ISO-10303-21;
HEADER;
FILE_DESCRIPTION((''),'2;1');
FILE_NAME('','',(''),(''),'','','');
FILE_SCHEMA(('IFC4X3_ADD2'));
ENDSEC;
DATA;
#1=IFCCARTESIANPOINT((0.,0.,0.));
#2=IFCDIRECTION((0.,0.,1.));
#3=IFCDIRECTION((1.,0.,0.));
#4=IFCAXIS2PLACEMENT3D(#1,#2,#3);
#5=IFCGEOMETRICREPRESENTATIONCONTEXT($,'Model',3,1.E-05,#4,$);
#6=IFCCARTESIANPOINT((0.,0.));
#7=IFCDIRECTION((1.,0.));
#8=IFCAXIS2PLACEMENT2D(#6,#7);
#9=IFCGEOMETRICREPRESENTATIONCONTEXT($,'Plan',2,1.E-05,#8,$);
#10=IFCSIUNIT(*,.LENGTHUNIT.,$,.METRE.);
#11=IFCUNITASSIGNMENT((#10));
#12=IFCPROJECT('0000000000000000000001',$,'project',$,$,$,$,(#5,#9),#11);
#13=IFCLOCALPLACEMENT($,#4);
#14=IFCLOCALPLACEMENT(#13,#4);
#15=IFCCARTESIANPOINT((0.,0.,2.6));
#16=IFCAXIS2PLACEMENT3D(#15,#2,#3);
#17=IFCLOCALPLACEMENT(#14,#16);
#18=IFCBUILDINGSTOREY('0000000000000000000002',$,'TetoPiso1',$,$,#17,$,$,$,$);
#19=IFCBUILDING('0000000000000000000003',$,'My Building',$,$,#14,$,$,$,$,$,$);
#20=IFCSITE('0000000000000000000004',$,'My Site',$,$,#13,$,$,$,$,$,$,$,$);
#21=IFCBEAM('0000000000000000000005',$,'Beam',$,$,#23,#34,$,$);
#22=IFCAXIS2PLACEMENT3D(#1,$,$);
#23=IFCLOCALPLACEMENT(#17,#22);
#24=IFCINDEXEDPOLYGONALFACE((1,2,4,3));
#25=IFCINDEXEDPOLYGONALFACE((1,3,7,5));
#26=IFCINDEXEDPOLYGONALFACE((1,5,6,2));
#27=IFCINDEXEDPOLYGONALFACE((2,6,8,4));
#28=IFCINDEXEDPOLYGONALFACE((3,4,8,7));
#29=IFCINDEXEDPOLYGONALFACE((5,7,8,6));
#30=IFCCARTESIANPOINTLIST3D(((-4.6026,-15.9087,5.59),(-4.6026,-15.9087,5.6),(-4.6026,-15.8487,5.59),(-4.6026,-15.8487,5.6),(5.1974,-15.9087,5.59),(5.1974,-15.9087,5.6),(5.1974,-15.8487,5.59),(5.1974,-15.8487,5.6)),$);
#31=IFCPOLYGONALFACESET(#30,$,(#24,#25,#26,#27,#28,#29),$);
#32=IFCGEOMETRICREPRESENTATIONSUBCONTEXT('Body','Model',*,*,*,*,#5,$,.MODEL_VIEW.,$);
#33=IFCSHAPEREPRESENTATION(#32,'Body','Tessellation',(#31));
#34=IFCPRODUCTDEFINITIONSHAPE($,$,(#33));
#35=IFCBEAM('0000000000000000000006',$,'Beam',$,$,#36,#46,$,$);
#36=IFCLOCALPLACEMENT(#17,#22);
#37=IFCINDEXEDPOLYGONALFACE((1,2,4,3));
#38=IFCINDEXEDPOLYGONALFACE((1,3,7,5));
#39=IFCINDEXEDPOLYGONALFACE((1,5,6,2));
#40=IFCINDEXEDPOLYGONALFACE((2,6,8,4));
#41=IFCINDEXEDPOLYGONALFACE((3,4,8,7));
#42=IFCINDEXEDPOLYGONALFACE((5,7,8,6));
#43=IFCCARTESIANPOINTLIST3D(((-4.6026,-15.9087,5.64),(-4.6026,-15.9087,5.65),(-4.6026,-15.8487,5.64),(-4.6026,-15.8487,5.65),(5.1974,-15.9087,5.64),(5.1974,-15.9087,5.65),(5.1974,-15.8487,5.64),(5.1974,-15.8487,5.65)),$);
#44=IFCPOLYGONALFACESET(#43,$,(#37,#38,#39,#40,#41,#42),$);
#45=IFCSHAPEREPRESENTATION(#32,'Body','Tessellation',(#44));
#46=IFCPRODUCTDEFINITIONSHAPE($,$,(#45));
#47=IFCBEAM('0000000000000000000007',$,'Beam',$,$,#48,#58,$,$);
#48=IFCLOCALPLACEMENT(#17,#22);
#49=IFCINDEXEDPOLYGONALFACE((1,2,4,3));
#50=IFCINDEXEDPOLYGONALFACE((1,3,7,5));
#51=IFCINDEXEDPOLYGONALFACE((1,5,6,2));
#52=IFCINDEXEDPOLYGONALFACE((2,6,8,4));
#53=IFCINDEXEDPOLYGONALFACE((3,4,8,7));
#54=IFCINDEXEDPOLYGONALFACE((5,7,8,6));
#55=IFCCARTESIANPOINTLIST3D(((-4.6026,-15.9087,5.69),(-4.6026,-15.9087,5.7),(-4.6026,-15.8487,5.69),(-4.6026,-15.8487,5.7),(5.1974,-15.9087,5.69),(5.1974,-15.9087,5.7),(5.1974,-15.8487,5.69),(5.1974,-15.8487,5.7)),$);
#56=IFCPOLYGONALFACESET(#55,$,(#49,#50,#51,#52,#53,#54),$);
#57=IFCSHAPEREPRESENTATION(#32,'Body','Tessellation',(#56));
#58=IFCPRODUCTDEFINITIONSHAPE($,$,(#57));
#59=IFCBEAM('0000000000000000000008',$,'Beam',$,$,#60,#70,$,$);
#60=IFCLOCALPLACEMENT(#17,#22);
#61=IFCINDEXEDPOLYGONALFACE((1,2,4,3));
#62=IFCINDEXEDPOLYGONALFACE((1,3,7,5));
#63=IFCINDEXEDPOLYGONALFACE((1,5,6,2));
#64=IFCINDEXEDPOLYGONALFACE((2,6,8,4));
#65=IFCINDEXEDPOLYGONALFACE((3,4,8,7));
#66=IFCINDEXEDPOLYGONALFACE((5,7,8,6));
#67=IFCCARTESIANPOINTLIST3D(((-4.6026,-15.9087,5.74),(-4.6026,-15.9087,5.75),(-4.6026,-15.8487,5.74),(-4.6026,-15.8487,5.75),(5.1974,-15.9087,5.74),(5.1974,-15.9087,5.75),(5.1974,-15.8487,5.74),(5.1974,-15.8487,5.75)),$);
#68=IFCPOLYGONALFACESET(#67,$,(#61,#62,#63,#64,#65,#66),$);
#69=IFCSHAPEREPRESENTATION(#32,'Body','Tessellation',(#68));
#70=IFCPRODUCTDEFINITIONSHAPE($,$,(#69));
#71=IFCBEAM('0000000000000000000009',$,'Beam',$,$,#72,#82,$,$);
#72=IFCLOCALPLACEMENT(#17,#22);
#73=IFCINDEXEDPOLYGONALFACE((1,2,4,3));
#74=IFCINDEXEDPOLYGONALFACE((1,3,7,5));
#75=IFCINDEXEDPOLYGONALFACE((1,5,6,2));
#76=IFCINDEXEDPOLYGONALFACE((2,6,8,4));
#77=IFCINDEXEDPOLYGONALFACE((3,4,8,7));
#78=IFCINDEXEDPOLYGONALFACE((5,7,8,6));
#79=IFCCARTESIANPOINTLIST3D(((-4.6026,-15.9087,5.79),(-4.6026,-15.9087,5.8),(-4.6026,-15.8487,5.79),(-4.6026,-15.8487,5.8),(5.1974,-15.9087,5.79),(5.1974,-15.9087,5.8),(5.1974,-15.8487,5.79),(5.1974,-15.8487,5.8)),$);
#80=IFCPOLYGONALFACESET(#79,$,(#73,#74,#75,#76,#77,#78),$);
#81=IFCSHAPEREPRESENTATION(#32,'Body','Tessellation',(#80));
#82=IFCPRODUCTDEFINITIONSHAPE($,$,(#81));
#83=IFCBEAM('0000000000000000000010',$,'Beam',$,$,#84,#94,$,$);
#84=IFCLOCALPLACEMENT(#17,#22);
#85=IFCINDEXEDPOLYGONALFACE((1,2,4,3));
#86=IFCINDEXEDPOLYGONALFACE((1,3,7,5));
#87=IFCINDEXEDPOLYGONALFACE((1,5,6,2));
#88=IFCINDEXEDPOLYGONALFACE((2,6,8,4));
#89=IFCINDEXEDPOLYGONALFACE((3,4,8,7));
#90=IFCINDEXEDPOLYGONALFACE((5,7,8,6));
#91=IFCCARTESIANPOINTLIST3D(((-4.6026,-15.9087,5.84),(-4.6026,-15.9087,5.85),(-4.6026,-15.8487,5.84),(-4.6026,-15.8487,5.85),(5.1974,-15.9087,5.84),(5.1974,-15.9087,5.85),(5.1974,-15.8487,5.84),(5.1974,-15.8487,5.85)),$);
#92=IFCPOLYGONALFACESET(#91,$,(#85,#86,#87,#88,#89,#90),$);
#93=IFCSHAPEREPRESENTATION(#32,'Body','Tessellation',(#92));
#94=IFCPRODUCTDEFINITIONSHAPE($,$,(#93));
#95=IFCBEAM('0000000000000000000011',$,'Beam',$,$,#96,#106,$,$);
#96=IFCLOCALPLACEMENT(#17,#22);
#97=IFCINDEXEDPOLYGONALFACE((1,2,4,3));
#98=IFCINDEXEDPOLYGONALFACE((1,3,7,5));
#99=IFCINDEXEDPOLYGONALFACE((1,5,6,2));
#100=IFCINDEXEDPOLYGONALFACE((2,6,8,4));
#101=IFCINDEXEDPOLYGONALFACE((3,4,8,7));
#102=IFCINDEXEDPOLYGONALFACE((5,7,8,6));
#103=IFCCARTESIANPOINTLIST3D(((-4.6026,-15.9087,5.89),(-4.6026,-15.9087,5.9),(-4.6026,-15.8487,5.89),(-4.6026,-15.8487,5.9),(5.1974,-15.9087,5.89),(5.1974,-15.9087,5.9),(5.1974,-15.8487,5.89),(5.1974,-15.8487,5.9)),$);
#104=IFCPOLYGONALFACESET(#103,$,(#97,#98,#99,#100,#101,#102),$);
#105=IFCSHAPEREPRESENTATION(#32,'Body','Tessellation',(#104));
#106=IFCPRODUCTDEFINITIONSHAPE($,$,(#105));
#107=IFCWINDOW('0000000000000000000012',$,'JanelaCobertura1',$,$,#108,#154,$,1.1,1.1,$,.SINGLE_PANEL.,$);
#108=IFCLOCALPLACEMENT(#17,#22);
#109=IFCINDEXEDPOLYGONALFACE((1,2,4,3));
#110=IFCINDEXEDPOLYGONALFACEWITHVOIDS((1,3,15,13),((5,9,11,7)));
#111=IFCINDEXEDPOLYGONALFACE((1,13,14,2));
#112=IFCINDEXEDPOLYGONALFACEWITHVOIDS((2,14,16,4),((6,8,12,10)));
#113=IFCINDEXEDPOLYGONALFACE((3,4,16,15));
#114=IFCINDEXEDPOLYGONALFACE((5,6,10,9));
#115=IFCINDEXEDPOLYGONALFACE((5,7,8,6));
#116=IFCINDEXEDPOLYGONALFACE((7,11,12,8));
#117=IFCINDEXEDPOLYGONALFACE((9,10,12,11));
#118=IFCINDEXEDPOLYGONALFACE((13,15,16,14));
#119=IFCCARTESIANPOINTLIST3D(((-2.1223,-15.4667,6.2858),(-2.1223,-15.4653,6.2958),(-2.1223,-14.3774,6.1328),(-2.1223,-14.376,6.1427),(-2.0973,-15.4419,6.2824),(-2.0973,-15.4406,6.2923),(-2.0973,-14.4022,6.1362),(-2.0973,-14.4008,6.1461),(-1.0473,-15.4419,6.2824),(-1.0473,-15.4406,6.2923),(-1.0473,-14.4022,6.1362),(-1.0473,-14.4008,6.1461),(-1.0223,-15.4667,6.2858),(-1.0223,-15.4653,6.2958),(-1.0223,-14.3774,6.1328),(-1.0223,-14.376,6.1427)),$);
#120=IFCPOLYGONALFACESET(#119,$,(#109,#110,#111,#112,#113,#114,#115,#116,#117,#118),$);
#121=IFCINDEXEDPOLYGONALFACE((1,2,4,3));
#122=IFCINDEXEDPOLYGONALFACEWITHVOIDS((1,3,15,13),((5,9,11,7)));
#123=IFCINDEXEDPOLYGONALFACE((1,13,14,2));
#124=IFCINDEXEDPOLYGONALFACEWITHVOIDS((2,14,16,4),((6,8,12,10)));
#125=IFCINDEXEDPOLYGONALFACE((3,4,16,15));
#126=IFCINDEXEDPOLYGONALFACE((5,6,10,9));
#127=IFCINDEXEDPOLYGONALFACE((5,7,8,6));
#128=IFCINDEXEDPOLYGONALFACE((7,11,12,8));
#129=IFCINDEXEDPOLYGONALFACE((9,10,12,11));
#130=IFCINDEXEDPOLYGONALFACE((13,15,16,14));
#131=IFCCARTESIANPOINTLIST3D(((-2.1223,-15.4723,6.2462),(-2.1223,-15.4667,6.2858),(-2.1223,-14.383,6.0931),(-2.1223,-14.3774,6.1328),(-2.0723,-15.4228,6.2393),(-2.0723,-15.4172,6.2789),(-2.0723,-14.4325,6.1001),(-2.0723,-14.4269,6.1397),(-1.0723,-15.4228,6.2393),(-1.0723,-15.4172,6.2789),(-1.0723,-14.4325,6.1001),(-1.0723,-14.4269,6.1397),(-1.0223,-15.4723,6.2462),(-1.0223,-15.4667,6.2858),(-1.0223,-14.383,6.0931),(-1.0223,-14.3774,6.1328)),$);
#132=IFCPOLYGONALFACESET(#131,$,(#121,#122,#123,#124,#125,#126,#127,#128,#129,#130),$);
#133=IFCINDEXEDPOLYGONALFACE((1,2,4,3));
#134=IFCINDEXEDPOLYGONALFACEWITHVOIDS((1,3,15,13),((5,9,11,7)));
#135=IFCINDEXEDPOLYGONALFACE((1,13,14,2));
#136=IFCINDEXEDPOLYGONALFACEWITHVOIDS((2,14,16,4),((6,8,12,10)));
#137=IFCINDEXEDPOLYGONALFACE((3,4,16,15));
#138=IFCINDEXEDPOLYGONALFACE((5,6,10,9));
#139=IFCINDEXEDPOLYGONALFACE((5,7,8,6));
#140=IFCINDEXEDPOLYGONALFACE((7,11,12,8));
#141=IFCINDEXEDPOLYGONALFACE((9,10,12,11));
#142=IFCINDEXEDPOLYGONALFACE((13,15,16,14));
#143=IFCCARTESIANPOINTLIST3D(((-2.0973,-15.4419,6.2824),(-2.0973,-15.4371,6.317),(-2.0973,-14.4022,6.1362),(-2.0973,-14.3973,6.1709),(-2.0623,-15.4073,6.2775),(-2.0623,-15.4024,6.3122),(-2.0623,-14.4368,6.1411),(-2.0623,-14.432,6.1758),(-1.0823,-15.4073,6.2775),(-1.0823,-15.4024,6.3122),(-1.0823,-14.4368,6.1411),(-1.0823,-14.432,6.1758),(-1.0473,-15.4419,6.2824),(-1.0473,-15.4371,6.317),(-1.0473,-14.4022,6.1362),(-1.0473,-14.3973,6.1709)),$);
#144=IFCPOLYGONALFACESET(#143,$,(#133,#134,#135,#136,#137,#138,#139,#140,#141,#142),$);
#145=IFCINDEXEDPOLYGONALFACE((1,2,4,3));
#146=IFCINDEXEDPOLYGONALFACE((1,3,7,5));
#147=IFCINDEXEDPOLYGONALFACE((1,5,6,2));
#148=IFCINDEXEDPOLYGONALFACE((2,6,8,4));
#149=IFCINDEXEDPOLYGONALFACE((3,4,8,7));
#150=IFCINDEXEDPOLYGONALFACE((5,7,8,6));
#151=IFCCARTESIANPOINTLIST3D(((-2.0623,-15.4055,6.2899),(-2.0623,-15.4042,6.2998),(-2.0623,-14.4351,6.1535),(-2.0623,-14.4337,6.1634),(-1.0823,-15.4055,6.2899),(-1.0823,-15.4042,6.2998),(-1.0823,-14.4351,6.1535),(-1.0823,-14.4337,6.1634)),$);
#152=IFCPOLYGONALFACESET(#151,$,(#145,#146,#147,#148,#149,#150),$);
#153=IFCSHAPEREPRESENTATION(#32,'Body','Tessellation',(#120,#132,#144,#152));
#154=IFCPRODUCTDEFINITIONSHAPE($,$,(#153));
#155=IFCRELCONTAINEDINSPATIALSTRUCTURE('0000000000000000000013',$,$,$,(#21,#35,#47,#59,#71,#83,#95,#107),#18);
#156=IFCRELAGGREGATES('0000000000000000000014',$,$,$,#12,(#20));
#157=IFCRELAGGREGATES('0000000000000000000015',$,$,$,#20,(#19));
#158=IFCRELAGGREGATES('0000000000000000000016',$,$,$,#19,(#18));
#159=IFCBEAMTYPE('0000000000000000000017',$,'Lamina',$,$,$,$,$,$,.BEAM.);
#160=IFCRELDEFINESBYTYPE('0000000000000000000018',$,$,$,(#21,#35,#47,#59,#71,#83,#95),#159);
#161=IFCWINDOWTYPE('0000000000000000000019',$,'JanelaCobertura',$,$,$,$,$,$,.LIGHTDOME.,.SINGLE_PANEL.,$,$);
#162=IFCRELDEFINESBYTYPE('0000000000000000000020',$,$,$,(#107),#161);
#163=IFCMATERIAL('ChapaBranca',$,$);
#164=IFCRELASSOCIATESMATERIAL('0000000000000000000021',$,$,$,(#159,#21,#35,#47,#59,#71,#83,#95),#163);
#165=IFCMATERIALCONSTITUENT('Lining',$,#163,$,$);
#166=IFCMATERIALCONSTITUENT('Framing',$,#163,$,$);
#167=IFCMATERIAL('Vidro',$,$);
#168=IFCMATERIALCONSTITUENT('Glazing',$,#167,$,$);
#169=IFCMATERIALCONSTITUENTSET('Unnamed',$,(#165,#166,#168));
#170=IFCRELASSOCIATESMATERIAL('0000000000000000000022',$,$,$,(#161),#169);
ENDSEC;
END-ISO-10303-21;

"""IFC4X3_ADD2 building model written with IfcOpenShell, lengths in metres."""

from ifc_helpers import new_model, entity, si_unit, frame, origin_with_axes, origin_2d, origin_2d_with_axis, place, context, subcontext, project, spatial, line, indexed_curve, rectangle, outline, extrude, shape, source, transform, mapped, material, constituent, constituent_set, material_profile, profile_set, profile_usage, type_object, type_shapes, element, save


model = new_model("IFC4X3_ADD2")

# Units and contexts
model_context = context("Model", 3, precision=1e-05, world=origin_with_axes())
plan_context = context("Plan", 2, precision=1e-05, world=origin_2d_with_axis())
body_context_1 = subcontext(model_context, "Body", "Model", "MODEL_VIEW")
body_context_2 = subcontext(plan_context, "Body", "Plan", "PLAN_VIEW")
ifc_project = project(units=[si_unit("LENGTHUNIT", "METRE")], contexts=[model_context, plan_context])

# Site, building, storey
site_placement = place(None, origin_with_axes())
site = spatial("IfcSite", under=ifc_project, at=site_placement, Name="My Site")
building_placement = place(site_placement, origin_with_axes())
building = spatial("IfcBuilding", under=site, at=building_placement, Name="My Building")
storey_placement = place(building_placement, frame((0.0, 0.0, 2.6), z_axis=(0.0, 0.0, 1.0), x_axis=(1.0, 0.0, 0.0)))
storey = spatial("IfcBuildingStorey", under=building, at=storey_placement, Name="TetoPiso1")

# Beams
ifc_material_1 = material(Name="ChapaBranca")
ifc_material_profile_1 = material_profile(ifc_material_1, rectangle(XDim=0.06, YDim=0.01, at=origin_2d()))
ifc_profile_set_1 = profile_set([ifc_material_profile_1])
beam_type_1 = type_object("IfcBeamType", Name="Lamina", PredefinedType="BEAM", material=ifc_profile_set_1)
ifc_profile_usage_1 = profile_usage(ifc_profile_set_1, cardinal=5)
beam_1_placement = place(storey_placement, frame((-4.6026, -15.8787, 5.595), z_axis=(1.0, 0.0, 0.0), x_axis=(0.0, 1.0, 0.0)))
element("IfcBeam", 1, at=beam_1_placement, inside=storey, type_object=beam_type_1, material=ifc_profile_usage_1, Name="Beam", context=body_context_1, shape_type="SweptSolid", body=[
    extrude(rectangle(XDim=0.06, YDim=0.01, at=origin_2d()), origin_with_axes(), (0.0, 0.0, 1.0), 9.8),
])
ifc_profile_usage_2 = profile_usage(ifc_profile_set_1, cardinal=5)
beam_2_placement = place(storey_placement, frame((-4.6026, -15.8787, 5.645), z_axis=(1.0, 0.0, 0.0), x_axis=(0.0, 1.0, 0.0)))
element("IfcBeam", 2, at=beam_2_placement, inside=storey, type_object=beam_type_1, material=ifc_profile_usage_2, Name="Beam", context=body_context_1, shape_type="SweptSolid", body=[
    extrude(rectangle(XDim=0.06, YDim=0.01, at=origin_2d()), origin_with_axes(), (0.0, 0.0, 1.0), 9.8),
])
ifc_profile_usage_3 = profile_usage(ifc_profile_set_1, cardinal=5)
beam_3_placement = place(storey_placement, frame((-4.6026, -15.8787, 5.695), z_axis=(1.0, 0.0, 0.0), x_axis=(0.0, 1.0, 0.0)))
element("IfcBeam", 3, at=beam_3_placement, inside=storey, type_object=beam_type_1, material=ifc_profile_usage_3, Name="Beam", context=body_context_1, shape_type="SweptSolid", body=[
    extrude(rectangle(XDim=0.06, YDim=0.01, at=origin_2d()), origin_with_axes(), (0.0, 0.0, 1.0), 9.8),
])
ifc_profile_usage_4 = profile_usage(ifc_profile_set_1, cardinal=5)
beam_4_placement = place(storey_placement, frame((-4.6026, -15.8787, 5.745), z_axis=(1.0, 0.0, 0.0), x_axis=(0.0, 1.0, 0.0)))
element("IfcBeam", 4, at=beam_4_placement, inside=storey, type_object=beam_type_1, material=ifc_profile_usage_4, Name="Beam", context=body_context_1, shape_type="SweptSolid", body=[
    extrude(rectangle(XDim=0.06, YDim=0.01, at=origin_2d()), origin_with_axes(), (0.0, 0.0, 1.0), 9.8),
])
ifc_profile_usage_5 = profile_usage(ifc_profile_set_1, cardinal=5)
beam_5_placement = place(storey_placement, frame((-4.6026, -15.8787, 5.795), z_axis=(1.0, 0.0, 0.0), x_axis=(0.0, 1.0, 0.0)))
element("IfcBeam", 5, at=beam_5_placement, inside=storey, type_object=beam_type_1, material=ifc_profile_usage_5, Name="Beam", context=body_context_1, shape_type="SweptSolid", body=[
    extrude(rectangle(XDim=0.06, YDim=0.01, at=origin_2d()), origin_with_axes(), (0.0, 0.0, 1.0), 9.8),
])
ifc_profile_usage_6 = profile_usage(ifc_profile_set_1, cardinal=5)
beam_6_placement = place(storey_placement, frame((-4.6026, -15.8787, 5.845), z_axis=(1.0, 0.0, 0.0), x_axis=(0.0, 1.0, 0.0)))
element("IfcBeam", 6, at=beam_6_placement, inside=storey, type_object=beam_type_1, material=ifc_profile_usage_6, Name="Beam", context=body_context_1, shape_type="SweptSolid", body=[
    extrude(rectangle(XDim=0.06, YDim=0.01, at=origin_2d()), origin_with_axes(), (0.0, 0.0, 1.0), 9.8),
])
ifc_profile_usage_7 = profile_usage(ifc_profile_set_1, cardinal=5)
beam_7_placement = place(storey_placement, frame((-4.6026, -15.8787, 5.895), z_axis=(1.0, 0.0, 0.0), x_axis=(0.0, 1.0, 0.0)))
element("IfcBeam", 7, at=beam_7_placement, inside=storey, type_object=beam_type_1, material=ifc_profile_usage_7, Name="Beam", context=body_context_1, shape_type="SweptSolid", body=[
    extrude(rectangle(XDim=0.06, YDim=0.01, at=origin_2d()), origin_with_axes(), (0.0, 0.0, 1.0), 9.8),
])

# Window
ifc_constituent_1 = constituent(ifc_material_1, Name="Lining")
ifc_constituent_2 = constituent(ifc_material_1, Name="Framing")
ifc_material_2 = material(Name="Vidro")
ifc_constituent_3 = constituent(ifc_material_2, Name="Glazing")
ifc_constituent_set = constituent_set(constituents=[ifc_constituent_1, ifc_constituent_2, ifc_constituent_3], Name="Unnamed")
window_type = type_object("IfcWindowType", Name="JanelaCobertura", PartitioningType="SINGLE_PANEL", PredefinedType="LIGHTDOME", material=ifc_constituent_set)
shared_shape_1 = source(origin_with_axes(), body_context_1, "Body", "SweptSolid", [
    extrude(outline(indexed_curve([(0.0, 0.0), (1.1, 0.0), (1.1, 1.1), (0.0, 1.1)], segments=[line(1, 2, 3, 4, 1)]), holes=[indexed_curve([(0.025, 0.025), (1.075, 0.025), (1.075, 1.075), (0.025, 1.075)], segments=[line(1, 2, 3, 4, 1)])]), frame((0.0, 0.09, 0.0), z_axis=(0.0, -1.0, 0.0), x_axis=(1.0, 0.0, 0.0)), (0.0, 0.0, -1.0), 0.01),
    extrude(outline(indexed_curve([(0.0, 0.0), (1.1, 0.0), (1.1, 1.1), (0.0, 1.1)], segments=[line(1, 2, 3, 4, 1)]), holes=[indexed_curve([(0.05, 0.05), (1.05, 0.05), (1.05, 1.05), (0.05, 1.05)], segments=[line(1, 2, 3, 4, 1)])]), frame((0.0, 0.05, 0.0), z_axis=(0.0, -1.0, 0.0), x_axis=(1.0, 0.0, 0.0)), (0.0, 0.0, -1.0), 0.04),
    extrude(outline(indexed_curve([(0.0, 0.0), (1.05, 0.0), (1.05, 1.05), (0.0, 1.05)], segments=[line(1, 2, 3, 4, 1)]), holes=[indexed_curve([(0.035, 0.035), (1.015, 0.035), (1.015, 1.015), (0.035, 1.015)], segments=[line(1, 2, 3, 4, 1)])]), frame((0.025, 0.09, 0.025), z_axis=(0.0, -1.0, 0.0), x_axis=(1.0, 0.0, 0.0)), (0.0, 0.0, -1.0), 0.035),
    extrude(outline(indexed_curve([(0.035, 0.035), (1.015, 0.035), (1.015, 1.015), (0.035, 1.015)], segments=[line(1, 2, 3, 4, 1)])), frame((0.025, 0.1025, 0.025), z_axis=(0.0, -1.0, 0.0), x_axis=(1.0, 0.0, 0.0)), (0.0, 0.0, -1.0), 0.01),
])
shared_shape_2 = source(origin_with_axes(), body_context_2, "Body", "Curve2D", [
    entity("IfcIndexedPolyCurve", entity("IfcCartesianPointList2D", [[0.05, 0.05], [1.05, 0.05]])),
    entity("IfcIndexedPolyCurve", entity("IfcCartesianPointList2D", [[0.0, 0.1], [0.025, 0.1], [0.025, 0.09], [0.05, 0.09], [0.05, 0.05], [0.0, 0.05]]), [entity("IfcLineIndex", [1, 2, 3, 4, 5, 6, 1])]),
    entity("IfcIndexedPolyCurve", entity("IfcCartesianPointList2D", [[1.1, 0.1], [1.075, 0.1], [1.075, 0.09], [1.05, 0.09], [1.05, 0.05], [1.1, 0.05]]), [entity("IfcLineIndex", [1, 2, 3, 4, 5, 6, 1])]),
    entity("IfcIndexedPolyCurve", entity("IfcCartesianPointList2D", [[0.025, 0.09], [0.06, 0.09], [0.06, 0.125], [0.025, 0.125]]), [entity("IfcLineIndex", [1, 2, 3, 4, 1])]),
    entity("IfcIndexedPolyCurve", entity("IfcCartesianPointList2D", [[1.075, 0.09], [1.04, 0.09], [1.04, 0.125], [1.075, 0.125]]), [entity("IfcLineIndex", [1, 2, 3, 4, 1])]),
    entity("IfcIndexedPolyCurve", entity("IfcCartesianPointList2D", [[0.06, 0.09], [1.04, 0.09]])),
    entity("IfcIndexedPolyCurve", entity("IfcCartesianPointList2D", [[0.06, 0.125], [1.04, 0.125]])),
    entity("IfcIndexedPolyCurve", entity("IfcCartesianPointList2D", [[0.06, 0.1075], [1.04, 0.1075]])),
])
type_shapes(window_type, [shared_shape_1, shared_shape_2])
window_1_placement = place(storey_placement, frame((-1.0223, -15.4792, 6.1967), z_axis=(0.0, 0.990268, -0.139173), x_axis=(-1.0, 0.0, 0.0)))
element("IfcWindow", 8, at=window_1_placement, inside=storey, type_object=window_type, Name="JanelaCobertura1", OverallHeight=1.1, OverallWidth=1.1, PartitioningType="SINGLE_PANEL", shapes=[
    shape(body_context_1, "Body", "MappedRepresentation", [mapped(shared_shape_1, transform((0.0, 0.0, 0.0), x_axis=(1.0, 0.0, 0.0), y_axis=(0.0, 1.0, 0.0), z_axis=(0.0, 0.0, 1.0), scale=1.0))]),
    shape(body_context_2, "Body", "MappedRepresentation", [mapped(shared_shape_2, transform((0.0, 0.0, 0.0), x_axis=(1.0, 0.0, 0.0), y_axis=(0.0, 1.0, 0.0), z_axis=(0.0, 0.0, 1.0), scale=1.0))]),
])

save(model, "model.ifc")
